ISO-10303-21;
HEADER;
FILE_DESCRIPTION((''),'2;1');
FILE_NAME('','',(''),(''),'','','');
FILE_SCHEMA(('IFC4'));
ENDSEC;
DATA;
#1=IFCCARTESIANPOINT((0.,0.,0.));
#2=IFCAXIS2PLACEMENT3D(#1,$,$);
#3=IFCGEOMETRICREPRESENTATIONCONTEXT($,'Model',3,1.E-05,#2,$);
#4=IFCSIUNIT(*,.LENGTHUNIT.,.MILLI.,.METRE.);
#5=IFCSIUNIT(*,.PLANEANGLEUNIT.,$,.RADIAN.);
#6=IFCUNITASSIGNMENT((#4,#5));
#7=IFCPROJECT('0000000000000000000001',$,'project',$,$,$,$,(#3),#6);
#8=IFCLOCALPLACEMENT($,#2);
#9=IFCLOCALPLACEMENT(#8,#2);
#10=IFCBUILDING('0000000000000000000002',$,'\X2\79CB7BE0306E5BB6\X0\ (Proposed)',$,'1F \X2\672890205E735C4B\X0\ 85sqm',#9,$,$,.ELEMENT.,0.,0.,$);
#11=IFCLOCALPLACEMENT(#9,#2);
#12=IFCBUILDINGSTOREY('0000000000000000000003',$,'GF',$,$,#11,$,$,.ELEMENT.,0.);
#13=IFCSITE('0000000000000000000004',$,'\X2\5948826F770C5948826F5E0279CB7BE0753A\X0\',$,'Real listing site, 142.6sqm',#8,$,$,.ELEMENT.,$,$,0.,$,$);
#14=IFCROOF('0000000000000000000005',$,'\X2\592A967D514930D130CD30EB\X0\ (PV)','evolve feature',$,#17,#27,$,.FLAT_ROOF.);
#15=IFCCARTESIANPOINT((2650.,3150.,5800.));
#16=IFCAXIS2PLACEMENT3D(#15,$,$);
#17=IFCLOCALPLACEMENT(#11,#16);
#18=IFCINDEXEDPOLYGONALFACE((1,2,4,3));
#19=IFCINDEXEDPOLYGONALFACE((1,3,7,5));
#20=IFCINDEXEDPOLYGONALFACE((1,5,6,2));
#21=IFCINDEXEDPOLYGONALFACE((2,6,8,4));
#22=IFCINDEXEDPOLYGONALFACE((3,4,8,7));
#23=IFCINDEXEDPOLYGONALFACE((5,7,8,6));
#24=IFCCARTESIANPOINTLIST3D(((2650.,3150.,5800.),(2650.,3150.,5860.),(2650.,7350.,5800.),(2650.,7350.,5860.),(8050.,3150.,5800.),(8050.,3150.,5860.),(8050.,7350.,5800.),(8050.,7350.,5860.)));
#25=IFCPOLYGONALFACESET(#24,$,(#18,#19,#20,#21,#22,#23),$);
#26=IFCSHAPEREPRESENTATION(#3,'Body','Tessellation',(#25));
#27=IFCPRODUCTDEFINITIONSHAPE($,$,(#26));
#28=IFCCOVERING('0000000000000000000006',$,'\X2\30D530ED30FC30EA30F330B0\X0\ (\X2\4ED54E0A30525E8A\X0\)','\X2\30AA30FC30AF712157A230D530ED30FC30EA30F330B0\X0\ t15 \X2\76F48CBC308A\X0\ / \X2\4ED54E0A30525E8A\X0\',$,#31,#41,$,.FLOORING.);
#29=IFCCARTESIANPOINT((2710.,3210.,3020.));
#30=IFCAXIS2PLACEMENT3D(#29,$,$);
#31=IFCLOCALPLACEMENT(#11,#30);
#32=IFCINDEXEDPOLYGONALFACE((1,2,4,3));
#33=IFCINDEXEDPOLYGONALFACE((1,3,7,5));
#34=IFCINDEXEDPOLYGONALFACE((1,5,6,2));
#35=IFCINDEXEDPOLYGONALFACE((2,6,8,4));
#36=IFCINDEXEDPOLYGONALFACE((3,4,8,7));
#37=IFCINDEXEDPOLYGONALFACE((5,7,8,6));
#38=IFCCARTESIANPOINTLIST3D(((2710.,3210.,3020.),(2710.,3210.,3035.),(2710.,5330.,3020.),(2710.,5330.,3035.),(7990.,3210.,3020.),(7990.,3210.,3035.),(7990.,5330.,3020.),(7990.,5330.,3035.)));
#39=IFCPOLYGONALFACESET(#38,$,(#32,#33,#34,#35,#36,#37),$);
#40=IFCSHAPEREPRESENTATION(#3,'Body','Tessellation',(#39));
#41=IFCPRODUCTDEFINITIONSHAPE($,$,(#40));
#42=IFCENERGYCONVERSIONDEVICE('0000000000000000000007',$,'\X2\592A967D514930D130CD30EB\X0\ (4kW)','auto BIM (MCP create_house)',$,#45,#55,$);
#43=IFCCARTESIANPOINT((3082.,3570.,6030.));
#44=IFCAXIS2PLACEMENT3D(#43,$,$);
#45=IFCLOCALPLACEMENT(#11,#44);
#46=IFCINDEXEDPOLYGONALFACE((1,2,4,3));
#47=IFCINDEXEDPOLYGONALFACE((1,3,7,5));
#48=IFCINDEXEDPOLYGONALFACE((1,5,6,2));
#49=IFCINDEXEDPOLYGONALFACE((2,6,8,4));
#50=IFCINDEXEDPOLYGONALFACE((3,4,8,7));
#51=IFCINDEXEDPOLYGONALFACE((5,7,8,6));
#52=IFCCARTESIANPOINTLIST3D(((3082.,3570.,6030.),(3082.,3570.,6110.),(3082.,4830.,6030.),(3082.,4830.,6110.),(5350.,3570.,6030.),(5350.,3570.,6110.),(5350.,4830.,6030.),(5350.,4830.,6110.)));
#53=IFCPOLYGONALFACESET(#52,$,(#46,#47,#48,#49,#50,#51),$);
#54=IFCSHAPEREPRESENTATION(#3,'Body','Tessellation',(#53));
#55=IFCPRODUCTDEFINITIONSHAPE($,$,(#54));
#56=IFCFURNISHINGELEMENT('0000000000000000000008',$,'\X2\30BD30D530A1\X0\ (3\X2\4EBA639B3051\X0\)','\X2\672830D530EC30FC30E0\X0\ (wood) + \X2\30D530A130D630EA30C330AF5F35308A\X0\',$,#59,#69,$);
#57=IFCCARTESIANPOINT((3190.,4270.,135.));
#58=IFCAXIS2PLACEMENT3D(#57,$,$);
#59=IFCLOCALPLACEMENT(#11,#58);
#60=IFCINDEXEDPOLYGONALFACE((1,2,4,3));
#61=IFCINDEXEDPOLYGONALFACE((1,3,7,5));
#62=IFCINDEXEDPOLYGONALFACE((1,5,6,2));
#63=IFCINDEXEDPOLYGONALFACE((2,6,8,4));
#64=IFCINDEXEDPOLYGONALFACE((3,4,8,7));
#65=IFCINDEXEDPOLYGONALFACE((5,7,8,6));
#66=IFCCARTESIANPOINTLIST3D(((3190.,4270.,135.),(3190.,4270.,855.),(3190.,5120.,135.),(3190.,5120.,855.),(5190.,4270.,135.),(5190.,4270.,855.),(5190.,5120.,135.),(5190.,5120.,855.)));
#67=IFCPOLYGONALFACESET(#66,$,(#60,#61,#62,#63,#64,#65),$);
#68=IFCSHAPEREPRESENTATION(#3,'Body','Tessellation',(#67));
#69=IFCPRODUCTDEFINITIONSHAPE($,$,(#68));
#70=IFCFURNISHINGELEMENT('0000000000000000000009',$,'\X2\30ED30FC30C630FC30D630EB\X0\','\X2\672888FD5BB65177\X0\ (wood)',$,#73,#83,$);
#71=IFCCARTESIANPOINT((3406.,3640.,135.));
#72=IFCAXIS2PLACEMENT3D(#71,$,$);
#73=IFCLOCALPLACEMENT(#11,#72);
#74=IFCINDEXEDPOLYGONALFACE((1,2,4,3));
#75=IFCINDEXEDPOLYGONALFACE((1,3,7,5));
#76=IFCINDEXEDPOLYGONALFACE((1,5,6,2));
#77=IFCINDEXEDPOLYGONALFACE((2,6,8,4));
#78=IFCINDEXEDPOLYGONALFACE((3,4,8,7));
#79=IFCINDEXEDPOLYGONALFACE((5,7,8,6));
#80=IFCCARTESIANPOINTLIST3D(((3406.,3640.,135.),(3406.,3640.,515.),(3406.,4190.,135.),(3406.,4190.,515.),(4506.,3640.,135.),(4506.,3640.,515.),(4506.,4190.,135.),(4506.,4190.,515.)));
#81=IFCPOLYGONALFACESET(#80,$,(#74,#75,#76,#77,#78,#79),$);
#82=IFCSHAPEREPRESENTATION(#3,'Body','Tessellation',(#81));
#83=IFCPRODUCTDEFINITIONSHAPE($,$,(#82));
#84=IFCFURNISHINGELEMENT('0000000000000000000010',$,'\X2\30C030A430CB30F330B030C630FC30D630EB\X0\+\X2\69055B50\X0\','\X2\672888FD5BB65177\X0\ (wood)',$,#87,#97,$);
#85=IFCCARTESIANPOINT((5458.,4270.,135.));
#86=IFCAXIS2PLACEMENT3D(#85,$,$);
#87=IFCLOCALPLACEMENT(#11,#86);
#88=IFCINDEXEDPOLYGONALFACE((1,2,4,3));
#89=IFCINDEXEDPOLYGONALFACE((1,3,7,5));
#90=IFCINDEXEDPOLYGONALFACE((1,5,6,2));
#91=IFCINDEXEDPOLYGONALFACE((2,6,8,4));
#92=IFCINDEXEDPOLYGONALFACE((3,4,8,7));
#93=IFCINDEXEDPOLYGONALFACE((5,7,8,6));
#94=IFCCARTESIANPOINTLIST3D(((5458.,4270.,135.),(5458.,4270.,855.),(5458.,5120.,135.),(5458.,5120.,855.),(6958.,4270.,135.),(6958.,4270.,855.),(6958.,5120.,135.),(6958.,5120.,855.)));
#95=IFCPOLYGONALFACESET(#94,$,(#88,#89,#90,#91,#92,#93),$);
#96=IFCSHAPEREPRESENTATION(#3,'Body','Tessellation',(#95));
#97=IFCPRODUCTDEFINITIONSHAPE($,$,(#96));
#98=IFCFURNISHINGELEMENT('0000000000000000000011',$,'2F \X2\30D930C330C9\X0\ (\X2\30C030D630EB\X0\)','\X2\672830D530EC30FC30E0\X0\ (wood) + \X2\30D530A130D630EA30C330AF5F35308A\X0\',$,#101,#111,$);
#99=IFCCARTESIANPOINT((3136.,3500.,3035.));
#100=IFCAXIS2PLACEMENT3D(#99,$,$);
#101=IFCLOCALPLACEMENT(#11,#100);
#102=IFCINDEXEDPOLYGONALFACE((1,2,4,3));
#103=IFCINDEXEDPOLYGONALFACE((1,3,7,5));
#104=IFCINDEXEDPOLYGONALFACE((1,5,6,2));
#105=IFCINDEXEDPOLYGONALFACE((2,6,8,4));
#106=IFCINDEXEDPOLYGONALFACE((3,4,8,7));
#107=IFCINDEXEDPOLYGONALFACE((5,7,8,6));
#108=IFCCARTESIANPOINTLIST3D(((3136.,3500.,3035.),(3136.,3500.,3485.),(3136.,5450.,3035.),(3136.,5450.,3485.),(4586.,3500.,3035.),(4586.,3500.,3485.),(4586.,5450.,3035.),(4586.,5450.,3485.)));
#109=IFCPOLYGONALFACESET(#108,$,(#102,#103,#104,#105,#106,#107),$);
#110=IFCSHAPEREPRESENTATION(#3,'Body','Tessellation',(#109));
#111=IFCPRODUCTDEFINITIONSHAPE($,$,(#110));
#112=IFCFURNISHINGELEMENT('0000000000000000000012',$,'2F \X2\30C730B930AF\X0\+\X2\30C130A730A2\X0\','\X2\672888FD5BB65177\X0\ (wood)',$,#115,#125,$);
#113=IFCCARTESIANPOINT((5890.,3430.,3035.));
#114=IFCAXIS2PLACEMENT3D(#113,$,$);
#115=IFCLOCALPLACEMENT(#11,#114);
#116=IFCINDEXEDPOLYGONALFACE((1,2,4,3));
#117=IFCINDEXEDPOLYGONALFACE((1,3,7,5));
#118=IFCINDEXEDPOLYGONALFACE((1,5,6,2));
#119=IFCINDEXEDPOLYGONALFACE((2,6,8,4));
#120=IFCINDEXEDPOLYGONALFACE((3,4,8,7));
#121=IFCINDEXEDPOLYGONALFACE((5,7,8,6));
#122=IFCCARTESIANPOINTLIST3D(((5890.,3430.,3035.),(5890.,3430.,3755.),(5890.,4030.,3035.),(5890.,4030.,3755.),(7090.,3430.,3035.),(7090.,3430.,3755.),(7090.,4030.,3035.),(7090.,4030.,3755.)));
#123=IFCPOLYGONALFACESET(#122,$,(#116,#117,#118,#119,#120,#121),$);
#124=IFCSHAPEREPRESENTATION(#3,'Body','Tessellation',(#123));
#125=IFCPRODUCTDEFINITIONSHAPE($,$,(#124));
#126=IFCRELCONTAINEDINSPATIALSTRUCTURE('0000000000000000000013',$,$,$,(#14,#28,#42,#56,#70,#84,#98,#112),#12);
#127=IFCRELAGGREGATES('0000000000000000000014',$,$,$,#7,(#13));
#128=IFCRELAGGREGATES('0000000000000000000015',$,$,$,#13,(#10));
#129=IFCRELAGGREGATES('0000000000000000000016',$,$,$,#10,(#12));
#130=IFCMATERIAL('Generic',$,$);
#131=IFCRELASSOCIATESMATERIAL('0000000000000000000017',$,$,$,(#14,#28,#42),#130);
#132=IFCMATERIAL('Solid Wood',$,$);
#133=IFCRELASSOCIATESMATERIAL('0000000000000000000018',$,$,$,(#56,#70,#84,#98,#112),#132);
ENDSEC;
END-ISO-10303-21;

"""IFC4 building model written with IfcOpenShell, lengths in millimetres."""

from ifc_helpers import new_model, si_unit, frame, frame_2d, origin, place, context, project, spatial, rectangle, extrude, material, element, save


model = new_model("IFC4")

# Units and contexts
model_context = context("Model", 3, precision=1e-05, world=origin())
ifc_project = project(units=[si_unit("LENGTHUNIT", "METRE", prefix="MILLI"), si_unit("PLANEANGLEUNIT", "RADIAN")], contexts=[model_context])

# Site, building, storey
site_placement = place(None, origin())
site = spatial("IfcSite", under=ifc_project, at=site_placement, Name="奈良県奈良市秋篠町", ObjectType="Real listing site, 142.6sqm", CompositionType="ELEMENT", RefElevation=0.0)
building_placement = place(site_placement, origin())
building = spatial("IfcBuilding", under=site, at=building_placement, Name="秋篠の家 (Proposed)", ObjectType="1F 木造平屋 85sqm", CompositionType="ELEMENT", ElevationOfRefHeight=0.0, ElevationOfTerrain=0.0)
storey_placement = place(building_placement, origin())
storey = spatial("IfcBuildingStorey", under=building, at=storey_placement, Name="GF", CompositionType="ELEMENT", Elevation=0.0)

# Shared definitions
ifc_material_1 = material(Name="Solid Wood")

# Roof
ifc_material_2 = material(Name="Generic")
roof_1_placement = place(storey_placement, frame((2650.0, 3150.0, 5800.0)))
element("IfcRoof", 1, at=roof_1_placement, inside=storey, material=ifc_material_2, Name="太陽光パネル (PV)", Description="evolve feature", PredefinedType="FLAT_ROOF", context=model_context, shape_type="SweptSolid", body=[
    extrude(rectangle(XDim=5400.0, YDim=4200.0, at=frame_2d((2700.0, 2100.0))), frame((2650.0, 3150.0, 5800.0)), (0.0, 0.0, 1.0), 60.0),
])

# Covering
covering_placement = place(storey_placement, frame((2710.0, 3210.0, 3020.0)))
element("IfcCovering", 2, at=covering_placement, inside=storey, material=ifc_material_2, Name="フローリング (仕上げ床)", Description="オーク無垢フローリング t15 直貼り / 仕上げ床", PredefinedType="FLOORING", context=model_context, shape_type="SweptSolid", body=[
    extrude(rectangle(XDim=5280.0, YDim=2120.0, at=frame_2d((2640.0, 1060.0))), frame((2710.0, 3210.0, 3020.0)), (0.0, 0.0, 1.0), 15.0),
])

# Energy conversion device
energy_conversion_device_placement = place(storey_placement, frame((3082.0, 3570.0, 6030.0)))
element("IfcEnergyConversionDevice", 3, at=energy_conversion_device_placement, inside=storey, material=ifc_material_2, Name="太陽光パネル (4kW)", Description="auto BIM (MCP create_house)", context=model_context, shape_type="SweptSolid", body=[
    extrude(rectangle(XDim=2268.0, YDim=1260.0, at=frame_2d((1134.0, 630.0))), frame((3082.0, 3570.0, 6030.0)), (0.0, 0.0, 1.0), 80.0),
])

# Furnishing elements
furnishing_1_placement = place(storey_placement, frame((3190.0, 4270.0, 135.0)))
element("IfcFurnishingElement", 4, at=furnishing_1_placement, inside=storey, material=ifc_material_1, Name="ソファ (3人掛け)", Description="木フレーム (wood) + ファブリック張り", context=model_context, shape_type="SweptSolid", body=[
    extrude(rectangle(XDim=2000.0, YDim=850.0, at=frame_2d((1000.0, 425.0))), frame((3190.0, 4270.0, 135.0)), (0.0, 0.0, 1.0), 720.0),
])
furnishing_2_placement = place(storey_placement, frame((3406.0, 3640.0, 135.0)))
element("IfcFurnishingElement", 5, at=furnishing_2_placement, inside=storey, material=ifc_material_1, Name="ローテーブル", Description="木製家具 (wood)", context=model_context, shape_type="SweptSolid", body=[
    extrude(rectangle(XDim=1100.0, YDim=550.0, at=frame_2d((550.0, 275.0))), frame((3406.0, 3640.0, 135.0)), (0.0, 0.0, 1.0), 380.0),
])
furnishing_3_placement = place(storey_placement, frame((5458.0, 4270.0, 135.0)))
element("IfcFurnishingElement", 6, at=furnishing_3_placement, inside=storey, material=ifc_material_1, Name="ダイニングテーブル+椅子", Description="木製家具 (wood)", context=model_context, shape_type="SweptSolid", body=[
    extrude(rectangle(XDim=1500.0, YDim=850.0, at=frame_2d((750.0, 425.0))), frame((5458.0, 4270.0, 135.0)), (0.0, 0.0, 1.0), 720.0),
])
furnishing_4_placement = place(storey_placement, frame((3136.0, 3500.0, 3035.0)))
element("IfcFurnishingElement", 7, at=furnishing_4_placement, inside=storey, material=ifc_material_1, Name="2F ベッド (ダブル)", Description="木フレーム (wood) + ファブリック張り", context=model_context, shape_type="SweptSolid", body=[
    extrude(rectangle(XDim=1450.0, YDim=1950.0, at=frame_2d((725.0, 975.0))), frame((3136.0, 3500.0, 3035.0)), (0.0, 0.0, 1.0), 450.0),
])
furnishing_5_placement = place(storey_placement, frame((5890.0, 3430.0, 3035.0)))
element("IfcFurnishingElement", 8, at=furnishing_5_placement, inside=storey, material=ifc_material_1, Name="2F デスク+チェア", Description="木製家具 (wood)", context=model_context, shape_type="SweptSolid", body=[
    extrude(rectangle(XDim=1200.0, YDim=600.0, at=frame_2d((600.0, 300.0))), frame((5890.0, 3430.0, 3035.0)), (0.0, 0.0, 1.0), 720.0),
])

save(model, "model.ifc")
